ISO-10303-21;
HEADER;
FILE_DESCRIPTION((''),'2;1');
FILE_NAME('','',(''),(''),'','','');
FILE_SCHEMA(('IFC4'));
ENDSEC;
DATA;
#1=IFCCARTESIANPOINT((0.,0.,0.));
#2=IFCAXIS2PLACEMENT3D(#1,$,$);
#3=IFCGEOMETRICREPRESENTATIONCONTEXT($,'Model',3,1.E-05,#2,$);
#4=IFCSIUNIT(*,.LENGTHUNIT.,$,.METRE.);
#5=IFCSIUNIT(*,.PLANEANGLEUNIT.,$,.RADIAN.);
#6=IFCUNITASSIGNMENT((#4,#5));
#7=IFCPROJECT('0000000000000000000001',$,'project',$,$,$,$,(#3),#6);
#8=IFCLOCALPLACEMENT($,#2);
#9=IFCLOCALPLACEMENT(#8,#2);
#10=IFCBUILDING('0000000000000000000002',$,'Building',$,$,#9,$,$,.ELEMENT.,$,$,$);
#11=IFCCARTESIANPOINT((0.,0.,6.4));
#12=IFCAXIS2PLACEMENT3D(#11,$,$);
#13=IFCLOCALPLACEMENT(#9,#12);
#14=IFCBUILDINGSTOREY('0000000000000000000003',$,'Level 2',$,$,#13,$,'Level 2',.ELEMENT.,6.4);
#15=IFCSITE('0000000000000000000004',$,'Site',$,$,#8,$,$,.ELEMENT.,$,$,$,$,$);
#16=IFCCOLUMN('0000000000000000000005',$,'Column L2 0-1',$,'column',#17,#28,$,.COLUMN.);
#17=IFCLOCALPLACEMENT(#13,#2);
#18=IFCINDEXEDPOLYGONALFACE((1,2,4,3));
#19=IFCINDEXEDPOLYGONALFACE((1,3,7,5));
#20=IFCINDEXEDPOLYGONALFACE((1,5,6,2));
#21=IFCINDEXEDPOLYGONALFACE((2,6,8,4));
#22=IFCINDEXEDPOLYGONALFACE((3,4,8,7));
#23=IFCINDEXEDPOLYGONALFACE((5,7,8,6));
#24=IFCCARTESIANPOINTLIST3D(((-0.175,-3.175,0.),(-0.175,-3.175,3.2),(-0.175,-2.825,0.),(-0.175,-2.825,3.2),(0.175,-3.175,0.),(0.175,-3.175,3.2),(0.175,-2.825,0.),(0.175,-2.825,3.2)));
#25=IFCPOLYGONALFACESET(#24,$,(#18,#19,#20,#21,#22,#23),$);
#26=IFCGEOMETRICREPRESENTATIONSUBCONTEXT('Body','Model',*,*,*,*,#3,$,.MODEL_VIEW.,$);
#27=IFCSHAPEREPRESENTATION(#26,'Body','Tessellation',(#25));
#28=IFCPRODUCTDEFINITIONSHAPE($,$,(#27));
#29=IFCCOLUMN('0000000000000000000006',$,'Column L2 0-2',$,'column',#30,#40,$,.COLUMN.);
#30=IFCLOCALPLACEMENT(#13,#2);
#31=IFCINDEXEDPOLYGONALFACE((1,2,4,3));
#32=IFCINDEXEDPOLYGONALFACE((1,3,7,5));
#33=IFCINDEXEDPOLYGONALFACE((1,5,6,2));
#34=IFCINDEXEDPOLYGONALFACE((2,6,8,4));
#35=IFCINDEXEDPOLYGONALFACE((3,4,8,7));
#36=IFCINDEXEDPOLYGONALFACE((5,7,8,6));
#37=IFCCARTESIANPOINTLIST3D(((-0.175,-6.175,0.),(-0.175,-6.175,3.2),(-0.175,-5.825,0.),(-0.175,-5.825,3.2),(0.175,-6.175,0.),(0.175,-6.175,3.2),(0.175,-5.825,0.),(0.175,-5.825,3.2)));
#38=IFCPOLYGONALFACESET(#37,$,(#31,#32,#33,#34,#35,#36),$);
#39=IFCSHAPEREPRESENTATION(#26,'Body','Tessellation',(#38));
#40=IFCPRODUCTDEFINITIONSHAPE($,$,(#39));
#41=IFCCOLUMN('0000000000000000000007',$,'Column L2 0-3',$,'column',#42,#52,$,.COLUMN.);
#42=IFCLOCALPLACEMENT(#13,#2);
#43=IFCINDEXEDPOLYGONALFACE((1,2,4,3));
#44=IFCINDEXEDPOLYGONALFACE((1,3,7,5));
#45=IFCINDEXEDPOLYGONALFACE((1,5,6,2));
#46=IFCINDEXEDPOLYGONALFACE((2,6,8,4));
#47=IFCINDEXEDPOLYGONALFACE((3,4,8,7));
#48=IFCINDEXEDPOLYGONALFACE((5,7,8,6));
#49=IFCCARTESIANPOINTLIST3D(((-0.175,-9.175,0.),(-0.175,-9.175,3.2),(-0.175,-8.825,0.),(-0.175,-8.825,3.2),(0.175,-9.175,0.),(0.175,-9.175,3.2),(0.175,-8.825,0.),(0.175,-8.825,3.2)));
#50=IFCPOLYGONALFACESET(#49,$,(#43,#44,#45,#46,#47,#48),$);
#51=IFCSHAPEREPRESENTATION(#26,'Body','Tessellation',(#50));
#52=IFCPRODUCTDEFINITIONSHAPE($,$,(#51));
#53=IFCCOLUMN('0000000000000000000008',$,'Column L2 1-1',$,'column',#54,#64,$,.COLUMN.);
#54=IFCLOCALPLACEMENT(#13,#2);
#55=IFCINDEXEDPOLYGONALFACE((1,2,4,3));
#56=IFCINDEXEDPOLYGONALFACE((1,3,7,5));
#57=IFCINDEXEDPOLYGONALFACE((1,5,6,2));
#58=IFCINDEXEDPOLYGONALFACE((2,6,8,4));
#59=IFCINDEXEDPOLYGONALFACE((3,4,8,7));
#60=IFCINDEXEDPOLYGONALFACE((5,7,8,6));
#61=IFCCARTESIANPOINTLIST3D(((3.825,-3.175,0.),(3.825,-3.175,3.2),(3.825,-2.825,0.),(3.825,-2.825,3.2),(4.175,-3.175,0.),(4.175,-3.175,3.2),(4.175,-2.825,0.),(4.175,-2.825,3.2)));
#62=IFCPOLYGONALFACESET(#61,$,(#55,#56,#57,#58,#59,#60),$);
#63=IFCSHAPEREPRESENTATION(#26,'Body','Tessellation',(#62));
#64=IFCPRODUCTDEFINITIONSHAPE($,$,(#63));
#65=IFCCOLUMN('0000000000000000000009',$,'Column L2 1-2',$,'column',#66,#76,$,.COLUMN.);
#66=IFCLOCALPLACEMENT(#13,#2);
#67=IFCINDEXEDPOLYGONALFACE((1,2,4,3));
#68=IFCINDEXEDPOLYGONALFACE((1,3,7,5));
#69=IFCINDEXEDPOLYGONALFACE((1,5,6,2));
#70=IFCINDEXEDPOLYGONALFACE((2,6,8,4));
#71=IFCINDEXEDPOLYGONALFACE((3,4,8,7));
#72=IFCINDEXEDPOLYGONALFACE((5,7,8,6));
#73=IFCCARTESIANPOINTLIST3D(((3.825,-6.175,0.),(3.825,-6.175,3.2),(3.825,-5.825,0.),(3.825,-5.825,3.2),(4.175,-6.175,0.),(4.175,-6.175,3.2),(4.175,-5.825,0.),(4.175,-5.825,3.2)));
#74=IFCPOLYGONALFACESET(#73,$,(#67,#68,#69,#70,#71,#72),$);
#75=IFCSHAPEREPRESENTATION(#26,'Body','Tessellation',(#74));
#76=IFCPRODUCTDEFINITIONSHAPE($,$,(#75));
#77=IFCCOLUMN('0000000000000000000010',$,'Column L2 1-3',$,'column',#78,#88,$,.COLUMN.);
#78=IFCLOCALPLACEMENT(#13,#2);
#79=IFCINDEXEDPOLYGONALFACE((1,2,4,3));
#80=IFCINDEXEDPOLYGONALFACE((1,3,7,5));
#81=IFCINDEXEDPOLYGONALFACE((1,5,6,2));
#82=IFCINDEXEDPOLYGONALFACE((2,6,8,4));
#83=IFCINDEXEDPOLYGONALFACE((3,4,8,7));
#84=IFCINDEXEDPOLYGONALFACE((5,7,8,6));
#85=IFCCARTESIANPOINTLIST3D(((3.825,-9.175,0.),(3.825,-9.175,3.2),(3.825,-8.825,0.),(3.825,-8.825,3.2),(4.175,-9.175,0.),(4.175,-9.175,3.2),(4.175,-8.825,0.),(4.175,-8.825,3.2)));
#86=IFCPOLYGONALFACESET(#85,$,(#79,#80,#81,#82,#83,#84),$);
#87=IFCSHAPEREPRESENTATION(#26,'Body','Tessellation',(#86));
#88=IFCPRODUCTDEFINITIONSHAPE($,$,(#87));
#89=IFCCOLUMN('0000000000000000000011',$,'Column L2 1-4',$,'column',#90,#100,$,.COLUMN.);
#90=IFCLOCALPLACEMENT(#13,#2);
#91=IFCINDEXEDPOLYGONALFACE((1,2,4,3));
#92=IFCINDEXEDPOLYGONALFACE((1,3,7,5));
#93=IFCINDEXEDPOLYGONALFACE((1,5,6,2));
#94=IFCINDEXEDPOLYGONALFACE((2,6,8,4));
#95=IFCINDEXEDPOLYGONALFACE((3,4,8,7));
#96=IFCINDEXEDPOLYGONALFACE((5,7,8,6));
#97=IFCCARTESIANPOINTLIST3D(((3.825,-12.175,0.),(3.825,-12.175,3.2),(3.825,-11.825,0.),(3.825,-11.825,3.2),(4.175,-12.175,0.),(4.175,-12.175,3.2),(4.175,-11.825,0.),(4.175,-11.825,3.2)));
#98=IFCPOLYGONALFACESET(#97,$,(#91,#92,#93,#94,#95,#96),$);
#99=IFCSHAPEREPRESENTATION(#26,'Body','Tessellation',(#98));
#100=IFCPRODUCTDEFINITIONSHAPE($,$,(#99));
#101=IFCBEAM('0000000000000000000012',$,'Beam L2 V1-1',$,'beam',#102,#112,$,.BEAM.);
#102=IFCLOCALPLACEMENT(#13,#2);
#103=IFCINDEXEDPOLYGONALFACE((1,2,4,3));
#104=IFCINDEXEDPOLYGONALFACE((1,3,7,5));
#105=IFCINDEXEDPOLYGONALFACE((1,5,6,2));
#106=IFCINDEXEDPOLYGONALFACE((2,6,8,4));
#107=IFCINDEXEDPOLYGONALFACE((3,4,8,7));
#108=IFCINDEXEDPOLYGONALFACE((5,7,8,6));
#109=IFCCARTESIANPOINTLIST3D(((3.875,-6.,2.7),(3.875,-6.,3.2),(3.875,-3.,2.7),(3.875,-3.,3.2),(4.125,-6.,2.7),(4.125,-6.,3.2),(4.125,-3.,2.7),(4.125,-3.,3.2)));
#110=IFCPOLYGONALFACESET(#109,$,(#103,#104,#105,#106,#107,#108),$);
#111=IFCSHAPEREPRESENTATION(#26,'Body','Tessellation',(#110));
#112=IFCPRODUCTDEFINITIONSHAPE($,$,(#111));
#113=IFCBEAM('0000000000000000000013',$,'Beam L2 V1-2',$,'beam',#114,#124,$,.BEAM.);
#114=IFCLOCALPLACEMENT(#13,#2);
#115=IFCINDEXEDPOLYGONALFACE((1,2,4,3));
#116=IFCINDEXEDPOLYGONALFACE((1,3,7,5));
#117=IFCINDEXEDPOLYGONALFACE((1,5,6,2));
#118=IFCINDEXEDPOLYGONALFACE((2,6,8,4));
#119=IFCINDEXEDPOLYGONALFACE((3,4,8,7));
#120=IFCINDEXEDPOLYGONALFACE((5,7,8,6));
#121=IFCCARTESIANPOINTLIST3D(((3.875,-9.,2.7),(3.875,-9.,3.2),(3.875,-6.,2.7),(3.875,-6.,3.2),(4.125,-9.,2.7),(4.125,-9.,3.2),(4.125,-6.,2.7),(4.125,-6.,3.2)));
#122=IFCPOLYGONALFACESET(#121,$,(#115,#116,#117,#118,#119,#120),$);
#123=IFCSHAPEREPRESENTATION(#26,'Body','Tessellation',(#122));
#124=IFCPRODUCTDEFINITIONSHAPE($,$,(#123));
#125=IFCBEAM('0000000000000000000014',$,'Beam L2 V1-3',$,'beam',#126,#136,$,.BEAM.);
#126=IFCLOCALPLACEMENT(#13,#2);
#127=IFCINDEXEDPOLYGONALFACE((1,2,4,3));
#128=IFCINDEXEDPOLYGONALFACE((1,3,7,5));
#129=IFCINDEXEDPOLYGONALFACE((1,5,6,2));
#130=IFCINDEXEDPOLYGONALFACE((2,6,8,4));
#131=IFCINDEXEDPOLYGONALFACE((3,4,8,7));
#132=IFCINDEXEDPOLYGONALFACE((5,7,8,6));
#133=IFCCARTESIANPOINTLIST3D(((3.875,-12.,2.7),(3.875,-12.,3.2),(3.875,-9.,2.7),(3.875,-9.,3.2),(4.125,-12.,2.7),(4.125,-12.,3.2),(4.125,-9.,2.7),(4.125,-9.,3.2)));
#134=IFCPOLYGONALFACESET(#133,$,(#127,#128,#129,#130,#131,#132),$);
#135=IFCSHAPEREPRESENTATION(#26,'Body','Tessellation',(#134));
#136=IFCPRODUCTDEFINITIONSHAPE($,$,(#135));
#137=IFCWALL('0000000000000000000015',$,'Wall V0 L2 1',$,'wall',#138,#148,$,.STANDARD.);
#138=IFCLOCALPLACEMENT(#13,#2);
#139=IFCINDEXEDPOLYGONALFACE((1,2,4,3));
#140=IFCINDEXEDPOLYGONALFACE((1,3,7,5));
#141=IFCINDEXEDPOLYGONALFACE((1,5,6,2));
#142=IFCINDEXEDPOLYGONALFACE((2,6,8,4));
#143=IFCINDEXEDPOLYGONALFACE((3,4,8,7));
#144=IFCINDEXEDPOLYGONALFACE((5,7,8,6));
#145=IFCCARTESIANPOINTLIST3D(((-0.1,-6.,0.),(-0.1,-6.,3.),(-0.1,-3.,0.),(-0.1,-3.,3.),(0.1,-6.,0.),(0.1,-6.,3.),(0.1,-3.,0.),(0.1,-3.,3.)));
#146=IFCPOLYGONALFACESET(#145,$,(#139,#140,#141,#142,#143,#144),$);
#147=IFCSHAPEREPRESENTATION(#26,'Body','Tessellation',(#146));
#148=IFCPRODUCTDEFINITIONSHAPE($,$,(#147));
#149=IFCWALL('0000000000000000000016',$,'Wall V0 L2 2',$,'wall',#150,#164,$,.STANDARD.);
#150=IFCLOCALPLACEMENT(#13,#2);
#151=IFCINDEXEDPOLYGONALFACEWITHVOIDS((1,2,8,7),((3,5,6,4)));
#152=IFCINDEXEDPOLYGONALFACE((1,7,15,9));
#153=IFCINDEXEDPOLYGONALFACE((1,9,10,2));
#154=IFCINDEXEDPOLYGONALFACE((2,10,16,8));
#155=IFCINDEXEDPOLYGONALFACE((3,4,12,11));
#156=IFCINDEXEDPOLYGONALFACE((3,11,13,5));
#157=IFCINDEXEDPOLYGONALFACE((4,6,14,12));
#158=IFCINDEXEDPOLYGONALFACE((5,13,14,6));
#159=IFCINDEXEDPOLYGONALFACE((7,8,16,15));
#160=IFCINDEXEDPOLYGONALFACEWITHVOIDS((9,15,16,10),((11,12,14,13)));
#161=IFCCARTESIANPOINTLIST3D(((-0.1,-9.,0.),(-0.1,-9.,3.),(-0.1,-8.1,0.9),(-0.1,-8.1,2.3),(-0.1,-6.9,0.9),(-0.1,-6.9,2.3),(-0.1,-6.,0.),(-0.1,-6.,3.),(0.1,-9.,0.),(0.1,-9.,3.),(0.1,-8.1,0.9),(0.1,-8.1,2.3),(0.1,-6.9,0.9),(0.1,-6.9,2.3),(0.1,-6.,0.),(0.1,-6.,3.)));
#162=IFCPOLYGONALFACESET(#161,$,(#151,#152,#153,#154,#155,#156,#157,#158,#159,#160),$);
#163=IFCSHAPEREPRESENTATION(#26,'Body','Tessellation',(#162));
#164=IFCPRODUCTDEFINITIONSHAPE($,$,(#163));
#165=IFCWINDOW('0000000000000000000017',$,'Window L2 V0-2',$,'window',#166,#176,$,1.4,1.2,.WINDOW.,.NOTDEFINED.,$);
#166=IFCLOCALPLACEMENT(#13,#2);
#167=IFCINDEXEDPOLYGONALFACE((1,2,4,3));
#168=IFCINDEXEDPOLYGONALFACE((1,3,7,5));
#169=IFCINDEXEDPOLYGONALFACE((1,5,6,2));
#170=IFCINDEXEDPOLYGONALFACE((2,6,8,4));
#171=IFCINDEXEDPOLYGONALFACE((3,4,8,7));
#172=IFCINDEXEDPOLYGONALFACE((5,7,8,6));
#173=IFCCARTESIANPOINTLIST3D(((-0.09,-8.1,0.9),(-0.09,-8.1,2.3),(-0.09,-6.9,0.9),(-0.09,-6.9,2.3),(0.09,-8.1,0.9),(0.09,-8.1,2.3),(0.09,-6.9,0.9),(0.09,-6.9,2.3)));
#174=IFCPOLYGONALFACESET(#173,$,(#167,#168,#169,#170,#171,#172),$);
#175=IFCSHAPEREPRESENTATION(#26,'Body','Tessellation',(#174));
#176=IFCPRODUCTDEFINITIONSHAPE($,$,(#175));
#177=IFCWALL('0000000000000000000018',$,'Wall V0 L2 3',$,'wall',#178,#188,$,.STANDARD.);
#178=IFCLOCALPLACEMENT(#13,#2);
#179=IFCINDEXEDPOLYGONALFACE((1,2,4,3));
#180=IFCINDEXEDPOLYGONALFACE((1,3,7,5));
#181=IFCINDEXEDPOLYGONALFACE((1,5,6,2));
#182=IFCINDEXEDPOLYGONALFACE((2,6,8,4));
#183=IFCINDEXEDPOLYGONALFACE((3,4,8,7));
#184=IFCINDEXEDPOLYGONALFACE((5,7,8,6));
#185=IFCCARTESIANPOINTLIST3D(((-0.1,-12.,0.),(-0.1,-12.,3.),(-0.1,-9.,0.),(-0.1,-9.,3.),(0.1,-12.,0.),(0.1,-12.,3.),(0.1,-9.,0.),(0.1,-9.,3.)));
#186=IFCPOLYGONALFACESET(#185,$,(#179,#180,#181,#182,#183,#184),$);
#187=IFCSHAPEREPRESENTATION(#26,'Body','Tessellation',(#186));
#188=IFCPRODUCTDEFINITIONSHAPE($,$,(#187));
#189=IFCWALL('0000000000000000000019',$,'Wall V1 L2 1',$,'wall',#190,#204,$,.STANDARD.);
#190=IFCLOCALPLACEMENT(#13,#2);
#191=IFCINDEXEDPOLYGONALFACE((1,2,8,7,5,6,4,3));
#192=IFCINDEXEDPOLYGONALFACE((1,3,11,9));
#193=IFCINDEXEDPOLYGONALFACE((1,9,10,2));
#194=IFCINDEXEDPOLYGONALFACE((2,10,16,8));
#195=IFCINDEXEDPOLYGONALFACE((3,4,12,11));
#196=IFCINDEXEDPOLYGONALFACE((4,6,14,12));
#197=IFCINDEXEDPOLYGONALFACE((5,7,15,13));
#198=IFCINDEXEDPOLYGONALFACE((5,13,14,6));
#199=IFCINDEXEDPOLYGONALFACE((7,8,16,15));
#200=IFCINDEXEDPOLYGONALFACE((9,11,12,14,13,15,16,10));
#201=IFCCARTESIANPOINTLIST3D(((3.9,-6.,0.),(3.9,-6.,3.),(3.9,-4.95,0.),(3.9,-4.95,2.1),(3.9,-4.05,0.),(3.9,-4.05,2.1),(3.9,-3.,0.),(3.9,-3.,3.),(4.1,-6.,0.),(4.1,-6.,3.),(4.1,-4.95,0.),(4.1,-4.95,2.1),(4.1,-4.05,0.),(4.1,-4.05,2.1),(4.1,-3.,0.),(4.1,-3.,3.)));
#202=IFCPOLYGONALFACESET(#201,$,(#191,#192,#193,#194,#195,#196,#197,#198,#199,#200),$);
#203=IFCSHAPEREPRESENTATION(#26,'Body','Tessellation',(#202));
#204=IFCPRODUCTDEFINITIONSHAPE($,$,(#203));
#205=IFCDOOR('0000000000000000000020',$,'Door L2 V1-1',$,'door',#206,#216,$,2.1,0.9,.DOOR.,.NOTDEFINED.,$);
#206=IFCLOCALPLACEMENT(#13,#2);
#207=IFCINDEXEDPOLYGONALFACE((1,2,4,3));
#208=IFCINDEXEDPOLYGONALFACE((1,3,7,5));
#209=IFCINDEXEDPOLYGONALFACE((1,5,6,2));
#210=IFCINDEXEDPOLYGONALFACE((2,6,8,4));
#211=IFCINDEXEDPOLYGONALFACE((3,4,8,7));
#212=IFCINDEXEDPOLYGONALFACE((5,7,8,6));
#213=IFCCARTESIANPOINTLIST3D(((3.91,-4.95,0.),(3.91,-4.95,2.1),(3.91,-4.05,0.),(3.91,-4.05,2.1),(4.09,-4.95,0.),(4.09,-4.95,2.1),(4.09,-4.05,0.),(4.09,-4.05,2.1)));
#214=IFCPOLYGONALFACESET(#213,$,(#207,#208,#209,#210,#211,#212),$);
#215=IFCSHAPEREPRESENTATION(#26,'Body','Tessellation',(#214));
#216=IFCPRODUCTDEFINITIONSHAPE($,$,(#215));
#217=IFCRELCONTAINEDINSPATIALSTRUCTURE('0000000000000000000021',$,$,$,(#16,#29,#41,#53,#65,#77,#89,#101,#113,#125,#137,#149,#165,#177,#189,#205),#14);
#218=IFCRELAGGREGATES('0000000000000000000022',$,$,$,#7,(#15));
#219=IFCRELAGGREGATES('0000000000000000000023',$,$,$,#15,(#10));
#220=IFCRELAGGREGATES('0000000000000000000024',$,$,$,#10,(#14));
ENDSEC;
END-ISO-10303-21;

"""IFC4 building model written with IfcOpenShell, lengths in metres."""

from ifc_helpers import new_model, si_unit, frame, frame_2d, origin, origin_2d, place, context, subcontext, project, spatial, rectangle, extrude, element, fill, save


model = new_model("IFC4")

# Units and contexts
model_context = context("Model", 3, precision=1e-05, world=origin())
body_context = subcontext(model_context, "Body", "Model", "MODEL_VIEW")
ifc_project = project(units=[si_unit("LENGTHUNIT", "METRE"), si_unit("PLANEANGLEUNIT", "RADIAN")], contexts=[model_context])

# Site, building, storey
site_placement = place(None, origin())
site = spatial("IfcSite", under=ifc_project, at=site_placement, Name="Site", CompositionType="ELEMENT")
building_placement = place(site_placement, origin())
building = spatial("IfcBuilding", under=site, at=building_placement, Name="Building", CompositionType="ELEMENT")
storey_placement = place(building_placement, frame((0.0, 0.0, 6.4)))
storey = spatial("IfcBuildingStorey", under=building, at=storey_placement, Name="Level 2", LongName="Level 2", CompositionType="ELEMENT", Elevation=6.4)

# Columns
for number, where, name in (
    (1, (0.0, -3.0, 0.0), "Column L2 0-1"),
    (2, (0.0, -6.0, 0.0), "Column L2 0-2"),
    (3, (0.0, -9.0, 0.0), "Column L2 0-3"),
    (4, (4.0, -3.0, 0.0), "Column L2 1-1"),
    (5, (4.0, -6.0, 0.0), "Column L2 1-2"),
    (6, (4.0, -9.0, 0.0), "Column L2 1-3"),
    (7, (4.0, -12.0, 0.0), "Column L2 1-4"),
):
    element("IfcColumn", number, at=place(storey_placement, frame(where)), inside=storey, Name=name, ObjectType="column", PredefinedType="COLUMN", context=body_context, shape_type="SweptSolid", body=[
        extrude(rectangle(XDim=0.35, YDim=0.35, at=origin_2d()), origin(), (0.0, 0.0, 1.0), 3.2),
    ])

# Beams
for number, where, z_axis, x_axis, name in (
    (8, (4.0, -3.0, 2.95), (0.0, -1.0, 0.0), (0.0, 0.0, 1.0), "Beam L2 V1-1"),
    (9, (4.0, -6.0, 2.95), (0.0, -1.0, 0.0), (0.0, 0.0, 1.0), "Beam L2 V1-2"),
    (10, (4.0, -9.0, 2.95), (0.0, -1.0, 0.0), (0.0, 0.0, 1.0), "Beam L2 V1-3"),
):
    element("IfcBeam", number, at=place(storey_placement, frame(where, z_axis=z_axis, x_axis=x_axis)), inside=storey, Name=name, ObjectType="beam", PredefinedType="BEAM", context=body_context, shape_type="SweptSolid", body=[
        extrude(rectangle(XDim=0.5, YDim=0.25, at=origin_2d()), origin(), (0.0, 0.0, 1.0), 3.0),
    ])

# Wall
wall_1_placement = place(storey_placement, frame((0.0, -3.0, 0.0), z_axis=(0.0, 0.0, 1.0), x_axis=(0.0, -1.0, 0.0)))
element("IfcWall", 11, at=wall_1_placement, inside=storey, Name="Wall V0 L2 1", ObjectType="wall", PredefinedType="STANDARD", context=body_context, shape_type="SweptSolid", body=[
    extrude(rectangle(XDim=3.0, YDim=0.2, at=frame_2d((1.5, 0.0))), origin(), (0.0, 0.0, 1.0), 3.0),
])

# Wall, opening, window
wall_2_placement = place(storey_placement, frame((0.0, -6.0, 0.0), z_axis=(0.0, 0.0, 1.0), x_axis=(0.0, -1.0, 0.0)))
wall_2 = element("IfcWall", 12, at=wall_2_placement, inside=storey, Name="Wall V0 L2 2", ObjectType="wall", PredefinedType="STANDARD", context=body_context, shape_type="SweptSolid", body=[
    extrude(rectangle(XDim=3.0, YDim=0.2, at=frame_2d((1.5, 0.0))), origin(), (0.0, 0.0, 1.0), 3.0),
])
opening_1_placement = place(storey_placement, frame((0.0, -7.5, 0.9), z_axis=(0.0, 0.0, 1.0), x_axis=(0.0, -1.0, 0.0)))
opening_1 = element("IfcOpeningElement", 13, at=opening_1_placement, cuts=wall_2, ObjectType="Opening", PredefinedType="OPENING", context=body_context, shape_type="SweptSolid", body=[
    extrude(rectangle(XDim=1.2, YDim=0.22, at=origin_2d()), origin(), (0.0, 0.0, 1.0), 1.4),
])
window_1_placement = place(storey_placement, frame((0.0, -7.5, 0.9), z_axis=(0.0, 0.0, 1.0), x_axis=(0.0, -1.0, 0.0)))
window_1 = element("IfcWindow", 14, at=window_1_placement, inside=storey, Name="Window L2 V0-2", ObjectType="window", OverallHeight=1.4, OverallWidth=1.2, PartitioningType="NOTDEFINED", PredefinedType="WINDOW", context=body_context, shape_type="SweptSolid", body=[
    extrude(rectangle(XDim=1.2, YDim=0.18, at=origin_2d()), origin(), (0.0, 0.0, 1.0), 1.4),
])
fill(opening_1, window_1)

# Wall
wall_3_placement = place(storey_placement, frame((0.0, -9.0, 0.0), z_axis=(0.0, 0.0, 1.0), x_axis=(0.0, -1.0, 0.0)))
element("IfcWall", 15, at=wall_3_placement, inside=storey, Name="Wall V0 L2 3", ObjectType="wall", PredefinedType="STANDARD", context=body_context, shape_type="SweptSolid", body=[
    extrude(rectangle(XDim=3.0, YDim=0.2, at=frame_2d((1.5, 0.0))), origin(), (0.0, 0.0, 1.0), 3.0),
])

# Wall, opening, door
wall_4_placement = place(storey_placement, frame((4.0, -3.0, 0.0), z_axis=(0.0, 0.0, 1.0), x_axis=(0.0, -1.0, 0.0)))
wall_4 = element("IfcWall", 16, at=wall_4_placement, inside=storey, Name="Wall V1 L2 1", ObjectType="wall", PredefinedType="STANDARD", context=body_context, shape_type="SweptSolid", body=[
    extrude(rectangle(XDim=3.0, YDim=0.2, at=frame_2d((1.5, 0.0))), origin(), (0.0, 0.0, 1.0), 3.0),
])
opening_2_placement = place(storey_placement, frame((4.0, -4.5, 0.0), z_axis=(0.0, 0.0, 1.0), x_axis=(0.0, -1.0, 0.0)))
opening_2 = element("IfcOpeningElement", 17, at=opening_2_placement, cuts=wall_4, ObjectType="Opening", PredefinedType="OPENING", context=body_context, shape_type="SweptSolid", body=[
    extrude(rectangle(XDim=0.9, YDim=0.22, at=origin_2d()), origin(), (0.0, 0.0, 1.0), 2.1),
])
door_1_placement = place(storey_placement, frame((4.0, -4.5, 0.0), z_axis=(0.0, 0.0, 1.0), x_axis=(0.0, -1.0, 0.0)))
door_1 = element("IfcDoor", 18, at=door_1_placement, inside=storey, Name="Door L2 V1-1", ObjectType="door", OperationType="NOTDEFINED", OverallHeight=2.1, OverallWidth=0.9, PredefinedType="DOOR", context=body_context, shape_type="SweptSolid", body=[
    extrude(rectangle(XDim=0.9, YDim=0.18, at=origin_2d()), origin(), (0.0, 0.0, 1.0), 2.1),
])
fill(opening_2, door_1)

save(model, "model.ifc")
